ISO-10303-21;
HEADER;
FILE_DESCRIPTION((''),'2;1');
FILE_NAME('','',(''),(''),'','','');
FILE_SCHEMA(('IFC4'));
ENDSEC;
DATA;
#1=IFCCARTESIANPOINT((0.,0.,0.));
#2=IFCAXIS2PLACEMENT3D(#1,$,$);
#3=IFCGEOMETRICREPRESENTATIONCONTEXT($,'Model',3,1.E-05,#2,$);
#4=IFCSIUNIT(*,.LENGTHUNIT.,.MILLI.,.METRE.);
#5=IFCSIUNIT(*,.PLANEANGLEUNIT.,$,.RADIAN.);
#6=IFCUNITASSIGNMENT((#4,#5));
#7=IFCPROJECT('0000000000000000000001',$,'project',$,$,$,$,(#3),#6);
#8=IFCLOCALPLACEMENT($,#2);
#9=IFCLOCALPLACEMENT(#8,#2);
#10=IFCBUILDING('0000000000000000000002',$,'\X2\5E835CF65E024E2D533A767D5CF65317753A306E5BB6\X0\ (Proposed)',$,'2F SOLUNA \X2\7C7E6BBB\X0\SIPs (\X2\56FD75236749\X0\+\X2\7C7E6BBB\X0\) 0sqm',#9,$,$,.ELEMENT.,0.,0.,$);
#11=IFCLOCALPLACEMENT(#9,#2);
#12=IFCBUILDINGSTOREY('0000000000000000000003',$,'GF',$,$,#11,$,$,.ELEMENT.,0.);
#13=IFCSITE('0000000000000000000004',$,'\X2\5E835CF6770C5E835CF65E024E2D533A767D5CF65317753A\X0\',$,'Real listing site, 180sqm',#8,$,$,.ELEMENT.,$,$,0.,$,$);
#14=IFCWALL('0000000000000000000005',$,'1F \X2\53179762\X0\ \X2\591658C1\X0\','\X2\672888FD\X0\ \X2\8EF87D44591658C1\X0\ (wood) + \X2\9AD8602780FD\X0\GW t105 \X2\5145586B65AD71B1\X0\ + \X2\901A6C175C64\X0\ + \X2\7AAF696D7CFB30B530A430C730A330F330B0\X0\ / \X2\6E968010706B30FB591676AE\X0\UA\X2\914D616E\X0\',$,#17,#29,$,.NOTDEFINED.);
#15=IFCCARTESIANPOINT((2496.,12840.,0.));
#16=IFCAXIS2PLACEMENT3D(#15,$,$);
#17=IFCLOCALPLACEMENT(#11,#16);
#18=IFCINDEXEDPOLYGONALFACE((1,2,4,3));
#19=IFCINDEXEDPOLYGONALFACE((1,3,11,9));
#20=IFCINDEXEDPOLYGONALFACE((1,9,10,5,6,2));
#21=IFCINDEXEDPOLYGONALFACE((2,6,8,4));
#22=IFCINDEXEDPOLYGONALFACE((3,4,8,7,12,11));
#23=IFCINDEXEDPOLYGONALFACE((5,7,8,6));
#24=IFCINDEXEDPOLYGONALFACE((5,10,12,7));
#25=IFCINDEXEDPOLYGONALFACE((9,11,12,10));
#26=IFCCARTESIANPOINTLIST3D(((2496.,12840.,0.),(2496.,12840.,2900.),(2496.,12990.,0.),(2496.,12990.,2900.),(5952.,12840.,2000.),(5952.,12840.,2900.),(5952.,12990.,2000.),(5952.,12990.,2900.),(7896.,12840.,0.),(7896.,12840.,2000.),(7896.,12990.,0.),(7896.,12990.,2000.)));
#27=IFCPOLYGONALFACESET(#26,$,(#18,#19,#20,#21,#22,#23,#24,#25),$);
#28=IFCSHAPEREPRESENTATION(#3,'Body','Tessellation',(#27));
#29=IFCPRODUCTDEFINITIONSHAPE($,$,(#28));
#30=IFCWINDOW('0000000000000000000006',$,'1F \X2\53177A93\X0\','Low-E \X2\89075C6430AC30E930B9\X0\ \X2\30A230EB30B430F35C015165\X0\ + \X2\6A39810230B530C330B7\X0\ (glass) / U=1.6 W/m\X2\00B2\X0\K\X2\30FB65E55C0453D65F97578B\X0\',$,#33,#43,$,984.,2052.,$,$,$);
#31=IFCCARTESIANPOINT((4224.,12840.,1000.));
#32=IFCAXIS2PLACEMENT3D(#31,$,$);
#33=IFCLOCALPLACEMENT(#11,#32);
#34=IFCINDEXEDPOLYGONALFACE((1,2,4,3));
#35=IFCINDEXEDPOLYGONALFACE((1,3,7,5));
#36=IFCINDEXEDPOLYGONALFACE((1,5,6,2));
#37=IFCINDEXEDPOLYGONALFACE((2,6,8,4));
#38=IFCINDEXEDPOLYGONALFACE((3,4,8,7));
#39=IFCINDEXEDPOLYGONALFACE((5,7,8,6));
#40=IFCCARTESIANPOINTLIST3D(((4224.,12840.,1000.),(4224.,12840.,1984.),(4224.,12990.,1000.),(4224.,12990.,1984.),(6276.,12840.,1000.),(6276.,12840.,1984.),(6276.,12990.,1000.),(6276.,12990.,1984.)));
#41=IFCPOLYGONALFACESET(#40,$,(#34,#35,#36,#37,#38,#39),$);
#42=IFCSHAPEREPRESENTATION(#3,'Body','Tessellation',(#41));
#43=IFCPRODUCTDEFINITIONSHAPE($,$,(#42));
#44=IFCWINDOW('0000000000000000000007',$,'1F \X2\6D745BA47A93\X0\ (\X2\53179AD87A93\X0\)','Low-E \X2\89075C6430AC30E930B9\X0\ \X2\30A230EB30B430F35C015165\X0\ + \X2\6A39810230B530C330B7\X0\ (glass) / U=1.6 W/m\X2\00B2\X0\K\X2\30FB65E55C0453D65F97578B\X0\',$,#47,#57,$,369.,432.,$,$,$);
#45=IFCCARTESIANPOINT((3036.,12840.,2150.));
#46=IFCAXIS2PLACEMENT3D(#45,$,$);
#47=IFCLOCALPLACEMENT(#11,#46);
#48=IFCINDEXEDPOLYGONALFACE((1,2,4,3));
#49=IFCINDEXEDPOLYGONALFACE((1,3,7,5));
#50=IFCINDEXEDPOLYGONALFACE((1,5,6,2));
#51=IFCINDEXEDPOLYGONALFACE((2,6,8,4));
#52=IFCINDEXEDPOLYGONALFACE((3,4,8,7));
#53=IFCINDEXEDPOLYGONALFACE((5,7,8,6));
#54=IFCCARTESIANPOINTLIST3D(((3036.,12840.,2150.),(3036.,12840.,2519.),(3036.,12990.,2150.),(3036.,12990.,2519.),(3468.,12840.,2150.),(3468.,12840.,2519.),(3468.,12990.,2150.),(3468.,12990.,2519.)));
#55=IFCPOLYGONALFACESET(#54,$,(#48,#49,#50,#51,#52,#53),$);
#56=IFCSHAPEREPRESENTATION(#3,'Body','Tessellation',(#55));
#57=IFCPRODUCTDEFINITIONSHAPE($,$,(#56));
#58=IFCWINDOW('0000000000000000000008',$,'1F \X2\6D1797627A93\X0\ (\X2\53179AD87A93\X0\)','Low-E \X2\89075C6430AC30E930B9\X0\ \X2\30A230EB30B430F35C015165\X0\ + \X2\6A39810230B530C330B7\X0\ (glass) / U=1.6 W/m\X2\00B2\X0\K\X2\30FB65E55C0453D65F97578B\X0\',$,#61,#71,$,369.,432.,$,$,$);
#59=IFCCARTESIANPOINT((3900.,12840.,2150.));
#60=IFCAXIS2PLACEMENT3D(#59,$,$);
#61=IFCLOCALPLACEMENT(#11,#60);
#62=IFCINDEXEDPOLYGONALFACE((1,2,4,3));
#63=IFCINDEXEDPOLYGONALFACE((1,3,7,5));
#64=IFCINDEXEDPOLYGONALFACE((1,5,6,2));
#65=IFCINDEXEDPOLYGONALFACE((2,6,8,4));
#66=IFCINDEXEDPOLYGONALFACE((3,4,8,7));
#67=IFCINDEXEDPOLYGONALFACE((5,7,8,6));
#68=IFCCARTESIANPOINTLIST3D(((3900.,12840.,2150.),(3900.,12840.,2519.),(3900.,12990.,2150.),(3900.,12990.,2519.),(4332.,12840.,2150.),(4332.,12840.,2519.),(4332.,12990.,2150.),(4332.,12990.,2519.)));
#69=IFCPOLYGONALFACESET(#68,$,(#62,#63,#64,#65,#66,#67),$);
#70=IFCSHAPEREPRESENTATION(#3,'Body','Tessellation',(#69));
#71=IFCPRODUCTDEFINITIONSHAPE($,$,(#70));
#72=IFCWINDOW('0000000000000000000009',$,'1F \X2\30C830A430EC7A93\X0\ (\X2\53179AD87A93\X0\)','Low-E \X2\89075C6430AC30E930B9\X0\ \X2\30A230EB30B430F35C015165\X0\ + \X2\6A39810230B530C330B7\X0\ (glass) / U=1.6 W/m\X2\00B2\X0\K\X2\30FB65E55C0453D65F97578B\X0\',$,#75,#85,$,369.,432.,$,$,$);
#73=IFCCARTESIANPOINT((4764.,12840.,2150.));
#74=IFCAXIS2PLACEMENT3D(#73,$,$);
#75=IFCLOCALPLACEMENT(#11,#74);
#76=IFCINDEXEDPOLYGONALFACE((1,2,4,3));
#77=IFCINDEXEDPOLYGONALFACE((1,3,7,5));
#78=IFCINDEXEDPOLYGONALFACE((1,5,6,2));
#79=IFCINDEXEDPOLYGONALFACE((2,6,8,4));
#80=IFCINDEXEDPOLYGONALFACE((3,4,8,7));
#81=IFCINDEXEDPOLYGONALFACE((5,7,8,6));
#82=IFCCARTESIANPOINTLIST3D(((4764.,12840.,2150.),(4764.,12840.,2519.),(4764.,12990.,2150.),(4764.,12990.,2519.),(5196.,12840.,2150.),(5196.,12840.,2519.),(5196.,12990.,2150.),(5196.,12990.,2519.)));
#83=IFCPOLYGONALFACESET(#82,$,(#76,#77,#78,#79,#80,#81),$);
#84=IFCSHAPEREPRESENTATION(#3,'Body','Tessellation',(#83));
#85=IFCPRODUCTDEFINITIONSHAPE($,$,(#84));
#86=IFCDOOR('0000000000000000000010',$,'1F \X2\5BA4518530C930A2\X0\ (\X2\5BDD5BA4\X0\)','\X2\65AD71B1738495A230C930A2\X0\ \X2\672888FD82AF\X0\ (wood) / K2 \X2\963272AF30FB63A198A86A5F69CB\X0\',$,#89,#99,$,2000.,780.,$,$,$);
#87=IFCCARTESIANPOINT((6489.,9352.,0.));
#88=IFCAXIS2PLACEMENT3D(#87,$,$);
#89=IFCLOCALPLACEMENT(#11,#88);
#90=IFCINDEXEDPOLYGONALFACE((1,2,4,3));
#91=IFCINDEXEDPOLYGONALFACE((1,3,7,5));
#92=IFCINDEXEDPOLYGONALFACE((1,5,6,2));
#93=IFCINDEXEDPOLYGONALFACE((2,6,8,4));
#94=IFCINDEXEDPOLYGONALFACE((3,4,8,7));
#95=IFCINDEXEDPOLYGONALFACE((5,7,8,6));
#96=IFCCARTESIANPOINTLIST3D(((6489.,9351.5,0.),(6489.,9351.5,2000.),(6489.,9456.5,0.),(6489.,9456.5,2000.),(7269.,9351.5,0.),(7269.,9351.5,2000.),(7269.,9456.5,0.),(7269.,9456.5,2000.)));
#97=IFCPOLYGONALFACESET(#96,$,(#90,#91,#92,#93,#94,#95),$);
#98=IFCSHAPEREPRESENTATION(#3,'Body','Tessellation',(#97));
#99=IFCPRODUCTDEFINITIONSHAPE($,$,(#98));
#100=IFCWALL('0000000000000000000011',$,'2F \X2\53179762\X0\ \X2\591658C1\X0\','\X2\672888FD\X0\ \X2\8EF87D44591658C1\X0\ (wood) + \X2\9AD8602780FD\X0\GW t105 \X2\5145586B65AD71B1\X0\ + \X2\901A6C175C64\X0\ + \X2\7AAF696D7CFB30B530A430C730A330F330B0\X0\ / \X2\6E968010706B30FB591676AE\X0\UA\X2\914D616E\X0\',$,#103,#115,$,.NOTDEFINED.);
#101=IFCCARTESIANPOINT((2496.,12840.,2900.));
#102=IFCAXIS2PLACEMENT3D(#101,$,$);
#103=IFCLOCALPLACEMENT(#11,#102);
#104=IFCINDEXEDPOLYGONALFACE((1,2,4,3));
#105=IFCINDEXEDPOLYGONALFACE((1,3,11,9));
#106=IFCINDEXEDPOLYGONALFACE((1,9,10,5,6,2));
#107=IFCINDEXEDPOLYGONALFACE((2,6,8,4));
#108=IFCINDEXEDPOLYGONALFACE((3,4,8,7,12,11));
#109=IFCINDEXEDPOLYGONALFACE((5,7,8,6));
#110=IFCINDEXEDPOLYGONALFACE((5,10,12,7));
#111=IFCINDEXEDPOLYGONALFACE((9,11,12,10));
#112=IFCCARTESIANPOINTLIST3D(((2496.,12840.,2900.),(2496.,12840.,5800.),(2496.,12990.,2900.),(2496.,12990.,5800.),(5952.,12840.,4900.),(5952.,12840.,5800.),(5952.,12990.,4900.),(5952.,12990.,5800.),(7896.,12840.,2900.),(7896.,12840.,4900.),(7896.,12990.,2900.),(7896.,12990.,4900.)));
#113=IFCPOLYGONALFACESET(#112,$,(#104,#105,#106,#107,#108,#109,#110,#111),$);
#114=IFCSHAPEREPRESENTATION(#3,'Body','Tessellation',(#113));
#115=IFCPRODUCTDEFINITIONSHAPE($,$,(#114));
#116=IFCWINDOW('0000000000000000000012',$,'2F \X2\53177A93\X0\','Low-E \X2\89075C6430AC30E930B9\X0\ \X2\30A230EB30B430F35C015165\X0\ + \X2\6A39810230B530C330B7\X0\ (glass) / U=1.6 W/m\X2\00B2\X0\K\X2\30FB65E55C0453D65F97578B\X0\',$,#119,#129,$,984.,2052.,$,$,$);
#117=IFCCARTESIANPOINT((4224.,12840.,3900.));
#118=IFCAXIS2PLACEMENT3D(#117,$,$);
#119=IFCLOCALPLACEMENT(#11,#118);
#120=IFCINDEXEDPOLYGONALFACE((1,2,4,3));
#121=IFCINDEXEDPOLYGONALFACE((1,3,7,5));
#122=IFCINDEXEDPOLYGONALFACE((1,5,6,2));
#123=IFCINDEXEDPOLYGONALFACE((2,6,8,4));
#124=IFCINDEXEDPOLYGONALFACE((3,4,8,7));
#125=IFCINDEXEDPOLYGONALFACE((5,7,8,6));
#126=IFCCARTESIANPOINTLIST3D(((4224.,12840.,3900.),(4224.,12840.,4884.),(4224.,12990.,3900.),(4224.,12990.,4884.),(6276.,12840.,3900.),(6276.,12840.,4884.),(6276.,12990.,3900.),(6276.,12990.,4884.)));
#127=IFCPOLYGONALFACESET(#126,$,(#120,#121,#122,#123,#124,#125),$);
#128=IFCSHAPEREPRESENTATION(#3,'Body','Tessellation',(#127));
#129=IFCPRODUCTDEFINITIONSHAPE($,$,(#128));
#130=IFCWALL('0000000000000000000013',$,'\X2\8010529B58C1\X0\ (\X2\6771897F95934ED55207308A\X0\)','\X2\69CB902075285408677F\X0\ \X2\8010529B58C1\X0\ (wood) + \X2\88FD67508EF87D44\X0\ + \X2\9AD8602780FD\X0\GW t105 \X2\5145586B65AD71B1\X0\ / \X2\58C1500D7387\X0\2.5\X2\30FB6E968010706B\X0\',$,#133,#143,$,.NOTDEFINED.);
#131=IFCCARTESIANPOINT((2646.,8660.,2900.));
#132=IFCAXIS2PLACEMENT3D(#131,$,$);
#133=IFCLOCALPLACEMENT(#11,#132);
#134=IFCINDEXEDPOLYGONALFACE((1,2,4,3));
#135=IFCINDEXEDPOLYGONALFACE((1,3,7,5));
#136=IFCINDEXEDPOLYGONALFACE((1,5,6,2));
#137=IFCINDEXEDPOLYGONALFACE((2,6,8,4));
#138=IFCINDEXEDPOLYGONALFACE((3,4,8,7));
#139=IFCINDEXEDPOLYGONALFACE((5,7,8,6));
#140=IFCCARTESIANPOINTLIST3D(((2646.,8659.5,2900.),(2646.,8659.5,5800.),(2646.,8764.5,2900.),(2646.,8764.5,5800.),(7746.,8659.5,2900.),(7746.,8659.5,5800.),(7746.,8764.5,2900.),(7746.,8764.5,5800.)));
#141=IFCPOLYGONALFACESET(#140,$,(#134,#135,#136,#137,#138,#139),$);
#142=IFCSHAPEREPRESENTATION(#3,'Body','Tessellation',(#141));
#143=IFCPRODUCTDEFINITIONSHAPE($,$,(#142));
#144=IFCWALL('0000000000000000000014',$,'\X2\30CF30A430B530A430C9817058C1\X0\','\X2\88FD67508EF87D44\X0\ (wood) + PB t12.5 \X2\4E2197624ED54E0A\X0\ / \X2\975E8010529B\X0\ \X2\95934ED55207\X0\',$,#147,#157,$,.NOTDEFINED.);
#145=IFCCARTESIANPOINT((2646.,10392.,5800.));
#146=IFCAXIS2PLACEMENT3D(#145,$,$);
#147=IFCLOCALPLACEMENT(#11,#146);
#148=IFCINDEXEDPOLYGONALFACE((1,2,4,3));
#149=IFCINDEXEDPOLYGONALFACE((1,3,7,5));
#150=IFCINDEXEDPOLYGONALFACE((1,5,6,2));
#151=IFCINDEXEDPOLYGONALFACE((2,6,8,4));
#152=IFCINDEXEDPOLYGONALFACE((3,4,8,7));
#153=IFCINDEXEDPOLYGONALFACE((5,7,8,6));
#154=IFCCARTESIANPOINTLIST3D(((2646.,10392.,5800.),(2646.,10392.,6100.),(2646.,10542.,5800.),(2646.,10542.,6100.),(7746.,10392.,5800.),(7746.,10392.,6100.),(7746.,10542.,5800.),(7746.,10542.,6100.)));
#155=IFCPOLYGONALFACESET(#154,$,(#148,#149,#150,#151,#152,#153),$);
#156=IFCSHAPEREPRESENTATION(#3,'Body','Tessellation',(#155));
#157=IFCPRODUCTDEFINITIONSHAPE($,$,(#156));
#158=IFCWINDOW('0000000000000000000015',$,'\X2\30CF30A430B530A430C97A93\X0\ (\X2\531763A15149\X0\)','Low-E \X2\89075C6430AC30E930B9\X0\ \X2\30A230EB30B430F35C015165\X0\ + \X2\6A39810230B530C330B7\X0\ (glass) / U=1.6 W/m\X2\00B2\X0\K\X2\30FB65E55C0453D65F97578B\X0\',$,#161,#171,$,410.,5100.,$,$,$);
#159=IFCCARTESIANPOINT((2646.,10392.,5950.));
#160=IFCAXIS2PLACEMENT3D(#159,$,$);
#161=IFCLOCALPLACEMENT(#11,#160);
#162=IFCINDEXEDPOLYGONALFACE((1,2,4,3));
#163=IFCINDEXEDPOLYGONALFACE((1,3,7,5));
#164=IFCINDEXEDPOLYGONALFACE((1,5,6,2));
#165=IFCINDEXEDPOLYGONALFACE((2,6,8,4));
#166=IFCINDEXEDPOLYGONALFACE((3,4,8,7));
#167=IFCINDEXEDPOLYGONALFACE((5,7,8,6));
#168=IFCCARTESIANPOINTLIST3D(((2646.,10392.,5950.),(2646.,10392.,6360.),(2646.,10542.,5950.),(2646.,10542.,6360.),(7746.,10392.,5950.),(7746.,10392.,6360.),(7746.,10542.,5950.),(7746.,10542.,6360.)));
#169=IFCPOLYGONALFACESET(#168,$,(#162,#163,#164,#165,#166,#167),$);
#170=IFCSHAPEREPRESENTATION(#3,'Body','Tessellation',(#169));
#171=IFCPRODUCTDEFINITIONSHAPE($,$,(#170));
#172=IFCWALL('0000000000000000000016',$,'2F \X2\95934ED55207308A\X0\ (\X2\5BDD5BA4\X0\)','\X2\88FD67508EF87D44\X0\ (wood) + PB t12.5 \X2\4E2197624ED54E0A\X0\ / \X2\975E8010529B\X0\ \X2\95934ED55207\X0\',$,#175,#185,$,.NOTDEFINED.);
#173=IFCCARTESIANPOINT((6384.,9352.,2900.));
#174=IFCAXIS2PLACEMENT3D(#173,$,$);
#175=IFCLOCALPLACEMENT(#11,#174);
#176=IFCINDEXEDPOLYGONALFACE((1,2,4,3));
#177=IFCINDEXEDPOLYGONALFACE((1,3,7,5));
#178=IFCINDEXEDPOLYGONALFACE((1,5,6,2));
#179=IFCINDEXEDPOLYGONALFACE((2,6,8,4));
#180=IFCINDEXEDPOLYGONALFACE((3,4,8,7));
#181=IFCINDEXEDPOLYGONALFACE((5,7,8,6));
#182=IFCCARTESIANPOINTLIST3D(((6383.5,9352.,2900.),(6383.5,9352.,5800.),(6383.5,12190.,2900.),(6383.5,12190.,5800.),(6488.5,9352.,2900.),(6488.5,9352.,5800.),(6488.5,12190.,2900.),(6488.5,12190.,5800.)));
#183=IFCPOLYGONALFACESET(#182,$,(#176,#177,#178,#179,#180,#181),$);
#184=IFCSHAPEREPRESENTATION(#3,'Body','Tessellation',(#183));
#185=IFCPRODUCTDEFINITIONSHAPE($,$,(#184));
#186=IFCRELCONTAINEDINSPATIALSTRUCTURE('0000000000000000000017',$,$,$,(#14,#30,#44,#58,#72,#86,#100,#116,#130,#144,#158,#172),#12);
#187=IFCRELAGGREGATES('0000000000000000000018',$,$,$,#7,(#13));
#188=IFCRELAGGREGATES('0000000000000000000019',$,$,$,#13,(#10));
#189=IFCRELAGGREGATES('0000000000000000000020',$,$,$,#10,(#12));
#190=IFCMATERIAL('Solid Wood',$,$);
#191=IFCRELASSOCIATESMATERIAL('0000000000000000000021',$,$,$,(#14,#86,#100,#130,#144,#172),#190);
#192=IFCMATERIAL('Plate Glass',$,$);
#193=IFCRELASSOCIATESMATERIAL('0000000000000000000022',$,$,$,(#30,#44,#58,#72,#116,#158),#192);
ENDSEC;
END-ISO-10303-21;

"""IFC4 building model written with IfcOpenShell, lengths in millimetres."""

from ifc_helpers import new_model, si_unit, frame, frame_2d, origin, place, context, project, spatial, rectangle, extrude, material, element, fill, save


model = new_model("IFC4")

# Units and contexts
model_context = context("Model", 3, precision=1e-05, world=origin())
ifc_project = project(units=[si_unit("LENGTHUNIT", "METRE", prefix="MILLI"), si_unit("PLANEANGLEUNIT", "RADIAN")], contexts=[model_context])

# Site, building, storey
site_placement = place(None, origin())
site = spatial("IfcSite", under=ifc_project, at=site_placement, Name="広島県広島市中区白島北町", ObjectType="Real listing site, 180sqm", CompositionType="ELEMENT", RefElevation=0.0)
building_placement = place(site_placement, origin())
building = spatial("IfcBuilding", under=site, at=building_placement, Name="広島市中区白島北町の家 (Proposed)", ObjectType="2F SOLUNA 籾殻SIPs (国産杉+籾殻) 0sqm", CompositionType="ELEMENT", ElevationOfRefHeight=0.0, ElevationOfTerrain=0.0)
storey_placement = place(building_placement, origin())
storey = spatial("IfcBuildingStorey", under=building, at=storey_placement, Name="GF", CompositionType="ELEMENT", Elevation=0.0)

# Wall, openings, windows
ifc_material_1 = material(Name="Solid Wood")
wall_1_placement = place(storey_placement, frame((2496.0, 12840.0, 0.0)))
wall_1 = element("IfcWall", 1, at=wall_1_placement, inside=storey, material=ifc_material_1, Name="1F 北面 外壁", Description="木製 軸組外壁 (wood) + 高性能GW t105 充填断熱 + 通気層 + 窯業系サイディング / 準耐火・外皮UA配慮", PredefinedType="NOTDEFINED", context=model_context, shape_type="SweptSolid", body=[
    extrude(rectangle(XDim=5400.0, YDim=150.0, at=frame_2d((2700.0, 75.0))), frame((2496.0, 12840.0, 0.0)), (0.0, 0.0, 1.0), 2900.0),
])
opening_1_placement = place(storey_placement, frame((4224.0, 12840.0, 1000.0)))
opening_1 = element("IfcOpeningElement", 2, at=opening_1_placement, cuts=wall_1, PredefinedType="NOTDEFINED", context=model_context, shape_type="SweptSolid", body=[
    extrude(rectangle(XDim=2052.0, YDim=150.0, at=frame_2d((1026.0, 75.0))), frame((4224.0, 12840.0, 1000.0)), (0.0, 0.0, 1.0), 984.0),
])
opening_2_placement = place(storey_placement, frame((3036.0, 12840.0, 2150.0)))
opening_2 = element("IfcOpeningElement", 3, at=opening_2_placement, cuts=wall_1, PredefinedType="NOTDEFINED", context=model_context, shape_type="SweptSolid", body=[
    extrude(rectangle(XDim=432.0, YDim=150.0, at=frame_2d((216.0, 75.0))), frame((3036.0, 12840.0, 2150.0)), (0.0, 0.0, 1.0), 369.0),
])
opening_3_placement = place(storey_placement, frame((3900.0, 12840.0, 2150.0)))
opening_3 = element("IfcOpeningElement", 4, at=opening_3_placement, cuts=wall_1, PredefinedType="NOTDEFINED", context=model_context, shape_type="SweptSolid", body=[
    extrude(rectangle(XDim=432.0, YDim=150.0, at=frame_2d((216.0, 75.0))), frame((3900.0, 12840.0, 2150.0)), (0.0, 0.0, 1.0), 369.0),
])
opening_4_placement = place(storey_placement, frame((4764.0, 12840.0, 2150.0)))
opening_4 = element("IfcOpeningElement", 5, at=opening_4_placement, cuts=wall_1, PredefinedType="NOTDEFINED", context=model_context, shape_type="SweptSolid", body=[
    extrude(rectangle(XDim=432.0, YDim=150.0, at=frame_2d((216.0, 75.0))), frame((4764.0, 12840.0, 2150.0)), (0.0, 0.0, 1.0), 369.0),
])
ifc_material_2 = material(Name="Plate Glass")
window_1_placement = place(storey_placement, frame((4224.0, 12840.0, 1000.0)))
window_1 = element("IfcWindow", 6, at=window_1_placement, inside=storey, material=ifc_material_2, Name="1F 北窓", Description="Low-E 複層ガラス アルゴン封入 + 樹脂サッシ (glass) / U=1.6 W/m²K・日射取得型", OverallHeight=984.0, OverallWidth=2052.0, context=model_context, shape_type="SweptSolid", body=[
    extrude(rectangle(XDim=2052.0, YDim=150.0, at=frame_2d((1026.0, 75.0))), frame((4224.0, 12840.0, 1000.0)), (0.0, 0.0, 1.0), 984.0),
])
fill(opening_1, window_1)
window_2_placement = place(storey_placement, frame((3036.0, 12840.0, 2150.0)))
window_2 = element("IfcWindow", 7, at=window_2_placement, inside=storey, material=ifc_material_2, Name="1F 浴室窓 (北高窓)", Description="Low-E 複層ガラス アルゴン封入 + 樹脂サッシ (glass) / U=1.6 W/m²K・日射取得型", OverallHeight=369.0, OverallWidth=432.0, context=model_context, shape_type="SweptSolid", body=[
    extrude(rectangle(XDim=432.0, YDim=150.0, at=frame_2d((216.0, 75.0))), frame((3036.0, 12840.0, 2150.0)), (0.0, 0.0, 1.0), 369.0),
])
fill(opening_2, window_2)
window_3_placement = place(storey_placement, frame((3900.0, 12840.0, 2150.0)))
window_3 = element("IfcWindow", 8, at=window_3_placement, inside=storey, material=ifc_material_2, Name="1F 洗面窓 (北高窓)", Description="Low-E 複層ガラス アルゴン封入 + 樹脂サッシ (glass) / U=1.6 W/m²K・日射取得型", OverallHeight=369.0, OverallWidth=432.0, context=model_context, shape_type="SweptSolid", body=[
    extrude(rectangle(XDim=432.0, YDim=150.0, at=frame_2d((216.0, 75.0))), frame((3900.0, 12840.0, 2150.0)), (0.0, 0.0, 1.0), 369.0),
])
fill(opening_3, window_3)
window_4_placement = place(storey_placement, frame((4764.0, 12840.0, 2150.0)))
window_4 = element("IfcWindow", 9, at=window_4_placement, inside=storey, material=ifc_material_2, Name="1F トイレ窓 (北高窓)", Description="Low-E 複層ガラス アルゴン封入 + 樹脂サッシ (glass) / U=1.6 W/m²K・日射取得型", OverallHeight=369.0, OverallWidth=432.0, context=model_context, shape_type="SweptSolid", body=[
    extrude(rectangle(XDim=432.0, YDim=150.0, at=frame_2d((216.0, 75.0))), frame((4764.0, 12840.0, 2150.0)), (0.0, 0.0, 1.0), 369.0),
])
fill(opening_4, window_4)

# Door
door_1_placement = place(storey_placement, frame((6489.0, 9352.0, 0.0)))
element("IfcDoor", 10, at=door_1_placement, inside=storey, material=ifc_material_1, Name="1F 室内ドア (寝室)", Description="断熱玄関ドア 木製芯 (wood) / K2 防犯・採風機構", OverallHeight=2000.0, OverallWidth=780.0, context=model_context, shape_type="SweptSolid", body=[
    extrude(rectangle(XDim=780.0, YDim=105.0, at=frame_2d((390.0, 52.0))), frame((6489.0, 9352.0, 0.0)), (0.0, 0.0, 1.0), 2000.0),
])

# Wall, opening, window
wall_2_placement = place(storey_placement, frame((2496.0, 12840.0, 2900.0)))
wall_2 = element("IfcWall", 11, at=wall_2_placement, inside=storey, material=ifc_material_1, Name="2F 北面 外壁", Description="木製 軸組外壁 (wood) + 高性能GW t105 充填断熱 + 通気層 + 窯業系サイディング / 準耐火・外皮UA配慮", PredefinedType="NOTDEFINED", context=model_context, shape_type="SweptSolid", body=[
    extrude(rectangle(XDim=5400.0, YDim=150.0, at=frame_2d((2700.0, 75.0))), frame((2496.0, 12840.0, 2900.0)), (0.0, 0.0, 1.0), 2900.0),
])
opening_5_placement = place(storey_placement, frame((4224.0, 12840.0, 3900.0)))
opening_5 = element("IfcOpeningElement", 12, at=opening_5_placement, cuts=wall_2, PredefinedType="NOTDEFINED", context=model_context, shape_type="SweptSolid", body=[
    extrude(rectangle(XDim=2052.0, YDim=150.0, at=frame_2d((1026.0, 75.0))), frame((4224.0, 12840.0, 3900.0)), (0.0, 0.0, 1.0), 984.0),
])
window_5_placement = place(storey_placement, frame((4224.0, 12840.0, 3900.0)))
window_5 = element("IfcWindow", 13, at=window_5_placement, inside=storey, material=ifc_material_2, Name="2F 北窓", Description="Low-E 複層ガラス アルゴン封入 + 樹脂サッシ (glass) / U=1.6 W/m²K・日射取得型", OverallHeight=984.0, OverallWidth=2052.0, context=model_context, shape_type="SweptSolid", body=[
    extrude(rectangle(XDim=2052.0, YDim=150.0, at=frame_2d((1026.0, 75.0))), frame((4224.0, 12840.0, 3900.0)), (0.0, 0.0, 1.0), 984.0),
])
fill(opening_5, window_5)

# Wall
wall_3_placement = place(storey_placement, frame((2646.0, 8660.0, 2900.0)))
element("IfcWall", 14, at=wall_3_placement, inside=storey, material=ifc_material_1, Name="耐力壁 (東西間仕切り)", Description="構造用合板 耐力壁 (wood) + 製材軸組 + 高性能GW t105 充填断熱 / 壁倍率2.5・準耐火", PredefinedType="NOTDEFINED", context=model_context, shape_type="SweptSolid", body=[
    extrude(rectangle(XDim=5100.0, YDim=105.0, at=frame_2d((2550.0, 52.0))), frame((2646.0, 8660.0, 2900.0)), (0.0, 0.0, 1.0), 2900.0),
])

# Wall, opening, window
wall_4_placement = place(storey_placement, frame((2646.0, 10392.0, 5800.0)))
wall_4 = element("IfcWall", 15, at=wall_4_placement, inside=storey, material=ifc_material_1, Name="ハイサイド腰壁", Description="製材軸組 (wood) + PB t12.5 両面仕上 / 非耐力 間仕切", PredefinedType="NOTDEFINED", context=model_context, shape_type="SweptSolid", body=[
    extrude(rectangle(XDim=5100.0, YDim=150.0, at=frame_2d((2550.0, 75.0))), frame((2646.0, 10392.0, 5800.0)), (0.0, 0.0, 1.0), 700.0),
])
opening_6_placement = place(storey_placement, frame((2646.0, 10392.0, 5950.0)))
opening_6 = element("IfcOpeningElement", 16, at=opening_6_placement, cuts=wall_4, PredefinedType="NOTDEFINED", context=model_context, shape_type="SweptSolid", body=[
    extrude(rectangle(XDim=5100.0, YDim=150.0, at=frame_2d((2550.0, 75.0))), frame((2646.0, 10392.0, 5950.0)), (0.0, 0.0, 1.0), 410.0),
])
window_6_placement = place(storey_placement, frame((2646.0, 10392.0, 5950.0)))
window_6 = element("IfcWindow", 17, at=window_6_placement, inside=storey, material=ifc_material_2, Name="ハイサイド窓 (北採光)", Description="Low-E 複層ガラス アルゴン封入 + 樹脂サッシ (glass) / U=1.6 W/m²K・日射取得型", OverallHeight=410.0, OverallWidth=5100.0, context=model_context, shape_type="SweptSolid", body=[
    extrude(rectangle(XDim=5100.0, YDim=150.0, at=frame_2d((2550.0, 75.0))), frame((2646.0, 10392.0, 5950.0)), (0.0, 0.0, 1.0), 410.0),
])
fill(opening_6, window_6)

# Wall
wall_5_placement = place(storey_placement, frame((6384.0, 9352.0, 2900.0)))
element("IfcWall", 18, at=wall_5_placement, inside=storey, material=ifc_material_1, Name="2F 間仕切り (寝室)", Description="製材軸組 (wood) + PB t12.5 両面仕上 / 非耐力 間仕切", PredefinedType="NOTDEFINED", context=model_context, shape_type="SweptSolid", body=[
    extrude(rectangle(XDim=105.0, YDim=2838.0, at=frame_2d((52.0, 1419.0))), frame((6384.0, 9352.0, 2900.0)), (0.0, 0.0, 1.0), 2900.0),
])

save(model, "model.ifc")
